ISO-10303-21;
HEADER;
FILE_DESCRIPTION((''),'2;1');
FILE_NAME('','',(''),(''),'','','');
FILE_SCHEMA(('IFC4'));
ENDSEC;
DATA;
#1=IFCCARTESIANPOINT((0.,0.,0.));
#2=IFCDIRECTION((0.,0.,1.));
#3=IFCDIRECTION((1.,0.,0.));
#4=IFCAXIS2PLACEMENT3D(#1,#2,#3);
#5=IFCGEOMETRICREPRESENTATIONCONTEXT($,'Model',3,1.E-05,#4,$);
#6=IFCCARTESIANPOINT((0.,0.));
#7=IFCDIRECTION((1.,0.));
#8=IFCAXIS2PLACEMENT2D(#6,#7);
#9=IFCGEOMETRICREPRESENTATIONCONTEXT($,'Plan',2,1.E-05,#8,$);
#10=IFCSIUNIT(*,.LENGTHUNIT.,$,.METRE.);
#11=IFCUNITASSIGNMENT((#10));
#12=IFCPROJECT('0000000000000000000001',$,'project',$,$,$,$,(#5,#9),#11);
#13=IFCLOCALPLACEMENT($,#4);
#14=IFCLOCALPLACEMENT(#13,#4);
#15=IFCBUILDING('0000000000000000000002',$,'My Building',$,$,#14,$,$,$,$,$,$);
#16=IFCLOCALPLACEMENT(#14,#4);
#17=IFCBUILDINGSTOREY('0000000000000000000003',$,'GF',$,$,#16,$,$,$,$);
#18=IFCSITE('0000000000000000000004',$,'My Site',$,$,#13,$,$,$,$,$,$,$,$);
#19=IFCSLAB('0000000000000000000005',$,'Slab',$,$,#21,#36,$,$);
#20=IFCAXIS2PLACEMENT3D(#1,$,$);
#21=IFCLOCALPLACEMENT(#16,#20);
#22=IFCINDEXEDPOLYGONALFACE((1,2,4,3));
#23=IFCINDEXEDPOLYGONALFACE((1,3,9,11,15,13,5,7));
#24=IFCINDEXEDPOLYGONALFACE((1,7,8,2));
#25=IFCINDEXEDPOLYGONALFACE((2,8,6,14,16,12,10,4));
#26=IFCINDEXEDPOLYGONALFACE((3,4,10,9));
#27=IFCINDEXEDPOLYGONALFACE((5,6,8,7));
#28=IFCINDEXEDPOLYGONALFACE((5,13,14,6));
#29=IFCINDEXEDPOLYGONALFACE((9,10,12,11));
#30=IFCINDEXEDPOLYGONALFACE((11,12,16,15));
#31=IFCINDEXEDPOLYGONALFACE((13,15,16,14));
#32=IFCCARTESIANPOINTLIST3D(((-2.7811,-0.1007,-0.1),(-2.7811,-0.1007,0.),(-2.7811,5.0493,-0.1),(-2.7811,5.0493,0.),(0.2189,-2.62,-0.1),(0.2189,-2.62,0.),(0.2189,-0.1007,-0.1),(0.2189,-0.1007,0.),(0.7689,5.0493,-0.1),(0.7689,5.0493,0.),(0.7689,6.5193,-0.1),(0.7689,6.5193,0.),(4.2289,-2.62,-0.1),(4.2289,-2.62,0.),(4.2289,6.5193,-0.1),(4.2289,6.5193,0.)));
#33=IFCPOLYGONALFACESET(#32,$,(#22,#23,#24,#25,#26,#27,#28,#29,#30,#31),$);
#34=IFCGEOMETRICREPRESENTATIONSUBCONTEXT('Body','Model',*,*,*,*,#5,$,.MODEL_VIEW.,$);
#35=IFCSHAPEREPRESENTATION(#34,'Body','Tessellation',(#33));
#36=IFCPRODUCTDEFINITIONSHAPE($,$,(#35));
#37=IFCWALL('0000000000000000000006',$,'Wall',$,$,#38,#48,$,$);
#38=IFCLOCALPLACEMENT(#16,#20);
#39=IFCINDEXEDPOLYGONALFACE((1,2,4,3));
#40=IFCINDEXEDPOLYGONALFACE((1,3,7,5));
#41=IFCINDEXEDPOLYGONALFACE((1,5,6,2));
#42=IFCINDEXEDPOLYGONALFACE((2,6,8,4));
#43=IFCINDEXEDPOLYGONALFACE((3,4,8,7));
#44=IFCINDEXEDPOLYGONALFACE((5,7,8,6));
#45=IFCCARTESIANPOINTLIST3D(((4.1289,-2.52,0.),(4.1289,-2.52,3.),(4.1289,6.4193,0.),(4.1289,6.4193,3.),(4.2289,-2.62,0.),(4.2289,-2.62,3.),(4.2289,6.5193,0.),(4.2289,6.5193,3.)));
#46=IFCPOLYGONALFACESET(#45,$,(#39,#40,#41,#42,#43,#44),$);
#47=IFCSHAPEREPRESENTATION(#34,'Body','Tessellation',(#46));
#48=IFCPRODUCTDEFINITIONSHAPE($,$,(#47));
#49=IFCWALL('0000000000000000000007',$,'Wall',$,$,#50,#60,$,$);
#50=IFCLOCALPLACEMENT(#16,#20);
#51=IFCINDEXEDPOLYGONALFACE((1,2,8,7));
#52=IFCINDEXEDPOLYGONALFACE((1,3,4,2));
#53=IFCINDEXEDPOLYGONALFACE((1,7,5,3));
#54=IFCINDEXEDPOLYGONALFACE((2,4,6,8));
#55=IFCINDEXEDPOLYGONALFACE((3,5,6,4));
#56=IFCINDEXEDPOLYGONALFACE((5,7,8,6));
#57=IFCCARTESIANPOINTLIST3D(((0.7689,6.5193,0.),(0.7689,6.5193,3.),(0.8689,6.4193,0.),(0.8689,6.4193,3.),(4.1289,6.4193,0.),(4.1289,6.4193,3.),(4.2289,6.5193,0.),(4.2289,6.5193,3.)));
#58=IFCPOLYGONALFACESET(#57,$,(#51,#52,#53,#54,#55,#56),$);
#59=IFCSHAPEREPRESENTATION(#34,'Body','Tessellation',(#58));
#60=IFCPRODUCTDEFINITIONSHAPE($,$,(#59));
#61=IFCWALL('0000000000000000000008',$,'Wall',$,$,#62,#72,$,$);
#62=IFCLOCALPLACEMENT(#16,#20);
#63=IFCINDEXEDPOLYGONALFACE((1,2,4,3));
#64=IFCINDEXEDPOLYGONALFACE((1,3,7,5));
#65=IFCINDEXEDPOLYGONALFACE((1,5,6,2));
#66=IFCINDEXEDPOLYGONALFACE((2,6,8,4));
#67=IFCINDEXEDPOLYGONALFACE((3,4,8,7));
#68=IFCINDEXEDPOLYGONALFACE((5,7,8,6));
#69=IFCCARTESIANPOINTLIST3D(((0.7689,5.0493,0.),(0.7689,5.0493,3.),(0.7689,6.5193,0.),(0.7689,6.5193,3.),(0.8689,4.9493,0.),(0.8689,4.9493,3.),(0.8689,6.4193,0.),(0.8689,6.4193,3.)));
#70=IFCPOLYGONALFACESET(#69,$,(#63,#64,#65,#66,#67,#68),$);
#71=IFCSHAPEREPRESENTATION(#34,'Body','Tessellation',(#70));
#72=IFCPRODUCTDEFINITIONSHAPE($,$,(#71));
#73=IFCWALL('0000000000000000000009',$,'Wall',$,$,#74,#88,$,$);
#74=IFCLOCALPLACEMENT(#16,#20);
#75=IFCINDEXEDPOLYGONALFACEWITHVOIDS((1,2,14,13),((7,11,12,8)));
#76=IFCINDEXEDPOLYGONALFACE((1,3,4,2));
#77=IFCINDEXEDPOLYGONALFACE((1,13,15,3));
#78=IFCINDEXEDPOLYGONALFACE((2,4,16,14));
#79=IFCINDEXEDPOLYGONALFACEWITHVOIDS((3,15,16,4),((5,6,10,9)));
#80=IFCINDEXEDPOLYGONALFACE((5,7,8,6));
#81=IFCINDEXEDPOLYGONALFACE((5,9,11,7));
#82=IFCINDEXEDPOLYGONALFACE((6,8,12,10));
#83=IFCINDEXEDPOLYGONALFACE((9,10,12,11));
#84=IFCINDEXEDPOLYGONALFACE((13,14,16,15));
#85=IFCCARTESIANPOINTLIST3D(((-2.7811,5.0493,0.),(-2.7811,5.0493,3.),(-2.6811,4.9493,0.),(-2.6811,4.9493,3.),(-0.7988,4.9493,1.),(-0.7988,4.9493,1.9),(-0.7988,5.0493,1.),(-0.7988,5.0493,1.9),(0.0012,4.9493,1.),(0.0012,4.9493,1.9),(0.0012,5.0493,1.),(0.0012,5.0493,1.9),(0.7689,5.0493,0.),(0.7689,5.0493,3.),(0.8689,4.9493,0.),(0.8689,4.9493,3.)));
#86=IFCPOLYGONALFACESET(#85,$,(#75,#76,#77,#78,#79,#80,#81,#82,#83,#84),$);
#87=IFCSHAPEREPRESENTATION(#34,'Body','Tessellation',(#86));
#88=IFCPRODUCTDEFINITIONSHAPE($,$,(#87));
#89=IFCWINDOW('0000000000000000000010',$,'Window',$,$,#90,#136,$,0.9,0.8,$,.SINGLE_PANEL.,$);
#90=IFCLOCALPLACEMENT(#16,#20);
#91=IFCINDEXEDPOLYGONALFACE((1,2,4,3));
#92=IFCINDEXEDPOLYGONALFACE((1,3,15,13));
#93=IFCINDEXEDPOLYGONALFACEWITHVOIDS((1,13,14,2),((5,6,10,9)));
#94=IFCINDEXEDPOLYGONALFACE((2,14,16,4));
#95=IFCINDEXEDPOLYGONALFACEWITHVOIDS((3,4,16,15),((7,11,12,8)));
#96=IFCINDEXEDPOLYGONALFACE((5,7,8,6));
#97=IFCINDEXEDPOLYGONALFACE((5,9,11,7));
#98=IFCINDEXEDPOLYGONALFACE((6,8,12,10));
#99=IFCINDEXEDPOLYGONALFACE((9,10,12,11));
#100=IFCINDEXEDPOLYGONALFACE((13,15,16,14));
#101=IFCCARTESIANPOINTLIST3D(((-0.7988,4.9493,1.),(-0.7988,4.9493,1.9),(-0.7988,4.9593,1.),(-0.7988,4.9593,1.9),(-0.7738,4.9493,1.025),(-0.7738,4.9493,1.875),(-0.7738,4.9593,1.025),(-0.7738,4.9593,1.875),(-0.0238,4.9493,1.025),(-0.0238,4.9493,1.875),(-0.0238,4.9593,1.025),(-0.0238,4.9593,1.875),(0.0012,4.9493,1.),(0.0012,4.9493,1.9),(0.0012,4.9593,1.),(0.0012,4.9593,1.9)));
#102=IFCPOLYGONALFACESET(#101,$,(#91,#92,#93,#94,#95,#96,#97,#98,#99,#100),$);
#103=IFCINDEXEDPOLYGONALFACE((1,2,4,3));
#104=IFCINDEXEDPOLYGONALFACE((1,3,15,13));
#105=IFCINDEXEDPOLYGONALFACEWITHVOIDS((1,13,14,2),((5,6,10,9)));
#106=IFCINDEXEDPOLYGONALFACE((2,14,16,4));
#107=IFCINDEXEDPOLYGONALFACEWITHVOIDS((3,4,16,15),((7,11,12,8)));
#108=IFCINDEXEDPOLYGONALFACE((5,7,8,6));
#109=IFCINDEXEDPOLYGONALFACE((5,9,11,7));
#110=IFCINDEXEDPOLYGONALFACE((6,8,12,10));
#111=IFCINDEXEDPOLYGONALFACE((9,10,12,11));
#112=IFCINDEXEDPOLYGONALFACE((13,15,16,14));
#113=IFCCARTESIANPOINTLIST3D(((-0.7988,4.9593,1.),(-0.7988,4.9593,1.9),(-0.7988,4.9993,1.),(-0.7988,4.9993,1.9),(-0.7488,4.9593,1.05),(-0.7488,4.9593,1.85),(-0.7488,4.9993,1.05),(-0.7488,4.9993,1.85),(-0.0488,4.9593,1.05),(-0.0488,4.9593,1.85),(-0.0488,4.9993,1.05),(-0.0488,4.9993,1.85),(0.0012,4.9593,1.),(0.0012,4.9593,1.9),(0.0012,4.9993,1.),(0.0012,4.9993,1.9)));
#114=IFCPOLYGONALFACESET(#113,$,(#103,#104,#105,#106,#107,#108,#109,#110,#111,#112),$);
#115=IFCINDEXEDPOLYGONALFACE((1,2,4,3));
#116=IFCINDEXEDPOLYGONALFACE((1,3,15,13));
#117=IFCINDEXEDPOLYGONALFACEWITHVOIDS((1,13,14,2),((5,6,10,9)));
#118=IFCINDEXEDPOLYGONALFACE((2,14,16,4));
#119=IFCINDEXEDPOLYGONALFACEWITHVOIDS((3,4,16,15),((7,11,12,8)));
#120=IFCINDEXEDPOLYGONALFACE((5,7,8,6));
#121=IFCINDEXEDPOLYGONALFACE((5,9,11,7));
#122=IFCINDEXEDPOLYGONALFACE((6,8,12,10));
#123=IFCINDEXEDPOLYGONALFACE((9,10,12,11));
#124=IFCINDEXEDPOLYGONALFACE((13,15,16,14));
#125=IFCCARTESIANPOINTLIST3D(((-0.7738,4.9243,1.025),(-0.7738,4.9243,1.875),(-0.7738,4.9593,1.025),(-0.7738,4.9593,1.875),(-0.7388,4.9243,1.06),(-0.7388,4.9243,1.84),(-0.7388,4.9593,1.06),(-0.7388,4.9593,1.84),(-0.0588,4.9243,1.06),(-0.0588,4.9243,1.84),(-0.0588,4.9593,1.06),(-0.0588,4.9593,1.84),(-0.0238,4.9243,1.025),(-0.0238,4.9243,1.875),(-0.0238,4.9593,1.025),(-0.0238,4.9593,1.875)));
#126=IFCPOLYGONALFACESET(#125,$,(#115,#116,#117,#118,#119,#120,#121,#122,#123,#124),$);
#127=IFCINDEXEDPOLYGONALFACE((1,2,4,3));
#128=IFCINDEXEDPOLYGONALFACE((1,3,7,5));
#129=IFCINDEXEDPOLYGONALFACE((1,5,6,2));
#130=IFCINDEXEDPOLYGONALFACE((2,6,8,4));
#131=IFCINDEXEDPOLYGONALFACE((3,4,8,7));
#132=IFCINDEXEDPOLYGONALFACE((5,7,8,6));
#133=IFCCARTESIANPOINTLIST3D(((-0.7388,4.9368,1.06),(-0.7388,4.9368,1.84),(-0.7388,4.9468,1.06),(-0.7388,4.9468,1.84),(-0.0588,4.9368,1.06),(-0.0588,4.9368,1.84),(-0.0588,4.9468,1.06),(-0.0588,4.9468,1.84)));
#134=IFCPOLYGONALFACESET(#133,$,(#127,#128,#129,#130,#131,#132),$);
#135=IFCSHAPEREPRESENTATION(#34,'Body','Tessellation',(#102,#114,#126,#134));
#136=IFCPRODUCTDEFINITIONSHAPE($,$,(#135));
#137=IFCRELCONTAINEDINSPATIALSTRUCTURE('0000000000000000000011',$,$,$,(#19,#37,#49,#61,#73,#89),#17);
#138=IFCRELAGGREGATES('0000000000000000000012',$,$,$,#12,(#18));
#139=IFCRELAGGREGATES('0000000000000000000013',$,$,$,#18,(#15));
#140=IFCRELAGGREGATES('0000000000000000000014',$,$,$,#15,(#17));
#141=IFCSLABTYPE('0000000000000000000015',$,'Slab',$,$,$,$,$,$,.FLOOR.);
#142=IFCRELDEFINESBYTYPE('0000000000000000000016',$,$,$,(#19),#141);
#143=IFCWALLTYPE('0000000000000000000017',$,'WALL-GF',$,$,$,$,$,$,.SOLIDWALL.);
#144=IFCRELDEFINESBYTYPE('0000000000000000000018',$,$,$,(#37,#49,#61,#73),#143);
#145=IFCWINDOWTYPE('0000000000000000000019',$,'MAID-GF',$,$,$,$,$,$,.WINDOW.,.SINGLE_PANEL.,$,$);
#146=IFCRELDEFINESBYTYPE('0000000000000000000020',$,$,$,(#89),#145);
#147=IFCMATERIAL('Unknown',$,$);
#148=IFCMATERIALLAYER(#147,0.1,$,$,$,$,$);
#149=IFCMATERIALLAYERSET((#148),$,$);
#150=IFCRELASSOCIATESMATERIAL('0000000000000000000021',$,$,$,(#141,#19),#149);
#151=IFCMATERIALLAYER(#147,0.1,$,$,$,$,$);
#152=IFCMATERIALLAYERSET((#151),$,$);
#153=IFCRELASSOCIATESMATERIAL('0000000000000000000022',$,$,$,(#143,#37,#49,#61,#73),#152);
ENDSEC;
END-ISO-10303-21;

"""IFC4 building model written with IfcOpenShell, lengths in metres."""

from ifc_helpers import new_model, entity, si_unit, frame, origin_with_axes, origin_2d_with_axis, place, context, subcontext, project, spatial, line, indexed_curve, outline, extrude, shape, source, transform, mapped, material, layer, layer_set, layer_usage, type_object, type_shapes, element, fill, save


model = new_model("IFC4")

# Units and contexts
model_context = context("Model", 3, precision=1e-05, world=origin_with_axes())
plan_context = context("Plan", 2, precision=1e-05, world=origin_2d_with_axis())
body_context_1 = subcontext(model_context, "Body", "Model", "MODEL_VIEW")
body_context_2 = subcontext(plan_context, "Body", "Plan", "PLAN_VIEW")
ifc_project = project(units=[si_unit("LENGTHUNIT", "METRE")], contexts=[model_context, plan_context])

# Site, building, storey
site_placement = place(None, origin_with_axes())
site = spatial("IfcSite", under=ifc_project, at=site_placement, Name="My Site")
building_placement = place(site_placement, origin_with_axes())
building = spatial("IfcBuilding", under=site, at=building_placement, Name="My Building")
storey_placement = place(building_placement, origin_with_axes())
storey = spatial("IfcBuildingStorey", under=building, at=storey_placement, Name="GF")

# Slab
ifc_material_1 = material(Name="Unknown")
ifc_layer_1 = layer(ifc_material_1, 0.1)
ifc_layer_set_1 = layer_set([ifc_layer_1])
ifc_layer_usage_1 = layer_usage(ifc_layer_set_1, "AXIS3", "POSITIVE", -0.1)
slab_type_1 = type_object("IfcSlabType", Name="Slab", PredefinedType="FLOOR", material=ifc_layer_set_1)
slab_1_placement = place(storey_placement, frame((4.2289, 6.5193, 0.0), z_axis=(0.0, 0.0, 1.0), x_axis=(1.0, 0.0, 0.0)))
element("IfcSlab", 1, at=slab_1_placement, inside=storey, type_object=slab_type_1, material=ifc_layer_usage_1, Name="Slab", context=body_context_1, shape_type="SweptSolid", body=[
    extrude(outline(indexed_curve([(0.0, 0.0), (-3.46, 0.0), (-3.46, -1.47), (-7.01, -1.47), (-7.01, -6.62), (-4.01, -6.62), (-4.01, -9.1393), (0.0, -9.1393), (0.0, 0.0)])), frame((0.0, 0.0, -0.1), z_axis=(0.0, 0.0, 1.0), x_axis=(1.0, 0.0, 0.0)), (0.0, 0.0, 1.0), 0.1),
])

# Shared definitions
ifc_layer_2 = layer(ifc_material_1, 0.1)
ifc_layer_set_2 = layer_set([ifc_layer_2])
wall_type = type_object("IfcWallType", Name="WALL-GF", PredefinedType="SOLIDWALL", material=ifc_layer_set_2)

# Walls
ifc_layer_usage_2 = layer_usage(ifc_layer_set_2, "AXIS2", "POSITIVE", 0.0)
wall_1_placement = place(storey_placement, frame((4.2289, -2.62, 0.0), z_axis=(0.0, 0.0, 1.0), x_axis=(0.0, 1.0, 0.0)))
element("IfcWall", 2, at=wall_1_placement, inside=storey, type_object=wall_type, material=ifc_layer_usage_2, Name="Wall", context=body_context_1, shape_type="SweptSolid", body=[
    extrude(outline(indexed_curve([(0.0, 0.0), (0.1, 0.1), (9.0393, 0.1), (9.1393, 0.0)], segments=[line(1, 2, 3, 4, 1)])), origin_with_axes(), (0.0, 0.0, 1.0), 3.0),
])
ifc_layer_usage_3 = layer_usage(ifc_layer_set_2, "AXIS2", "POSITIVE", 0.0)
wall_2_placement = place(storey_placement, frame((4.2289, 6.5193, 0.0), z_axis=(0.0, 0.0, 1.0), x_axis=(-1.0, 0.0, 0.0)))
element("IfcWall", 3, at=wall_2_placement, inside=storey, type_object=wall_type, material=ifc_layer_usage_3, Name="Wall", context=body_context_1, shape_type="SweptSolid", body=[
    extrude(outline(indexed_curve([(0.0, 0.0), (0.1, 0.1), (3.36, 0.1), (3.46, 0.0)], segments=[line(1, 2, 3, 4, 1)])), origin_with_axes(), (0.0, 0.0, 1.0), 3.0),
])
ifc_layer_usage_4 = layer_usage(ifc_layer_set_2, "AXIS2", "POSITIVE", 0.0)
wall_3_placement = place(storey_placement, frame((0.7689, 6.5193, 0.0), z_axis=(0.0, 0.0, 1.0), x_axis=(0.0, -1.0, 0.0)))
element("IfcWall", 4, at=wall_3_placement, inside=storey, type_object=wall_type, material=ifc_layer_usage_4, Name="Wall", context=body_context_1, shape_type="SweptSolid", body=[
    extrude(outline(indexed_curve([(0.0, 0.0), (0.1, 0.1), (1.57, 0.1), (1.47, 0.0)], segments=[line(1, 2, 3, 4, 1)])), origin_with_axes(), (0.0, 0.0, 1.0), 3.0),
])

# Wall, opening, window
ifc_layer_usage_5 = layer_usage(ifc_layer_set_2, "AXIS2", "POSITIVE", 0.0)
wall_4_placement = place(storey_placement, frame((0.7689, 5.0493, 0.0), z_axis=(0.0, 0.0, 1.0), x_axis=(-1.0, 0.0, 0.0)))
wall_4 = element("IfcWall", 5, at=wall_4_placement, inside=storey, type_object=wall_type, material=ifc_layer_usage_5, Name="Wall", context=body_context_1, shape_type="SweptSolid", body=[
    extrude(outline(indexed_curve([(0.0, 0.0), (-0.1, 0.1), (3.45, 0.1), (3.55, 0.0)], segments=[line(1, 2, 3, 4, 1)])), origin_with_axes(), (0.0, 0.0, 1.0), 3.0),
])
shared_shape_1 = source(origin_with_axes(), body_context_1, "Body", "SweptSolid", [
    extrude(outline(indexed_curve([(0.0, 0.0), (0.8, 0.0), (0.8, 0.9), (0.0, 0.9)], segments=[line(1, 2, 3, 4, 1)])), frame((0.0, -0.6, 0.0), z_axis=(0.0, -1.0, 0.0), x_axis=(1.0, 0.0, 0.0)), (0.0, 0.0, -1.0), 1.2),
])
opening_1_placement = place(wall_4_placement, frame((0.7678, 0.0, 1.0), z_axis=(0.0, 0.0, 1.0), x_axis=(1.0, 0.0, 0.0)))
opening_1 = element("IfcOpeningElement", 6, at=opening_1_placement, cuts=wall_4, PredefinedType="OPENING", context=body_context_1, shape_type="MappedRepresentation", body=[
    mapped(shared_shape_1, transform((0.0, 0.0, 0.0), x_axis=(1.0, 0.0, 0.0), y_axis=(0.0, 1.0, 0.0), z_axis=(0.0, 0.0, 1.0), scale=1.0)),
])
window_type_1 = type_object("IfcWindowType", Name="MAID-GF", PartitioningType="SINGLE_PANEL", PredefinedType="WINDOW")
shared_shape_2 = source(origin_with_axes(), body_context_1, "Body", "SweptSolid", [
    extrude(outline(indexed_curve([(0.0, 0.0), (0.8, 0.0), (0.8, 0.9), (0.0, 0.9)], segments=[line(1, 2, 3, 4, 1)]), holes=[indexed_curve([(0.025, 0.025), (0.775, 0.025), (0.775, 0.875), (0.025, 0.875)], segments=[line(1, 2, 3, 4, 1)])]), frame((0.0, 0.09, 0.0), z_axis=(0.0, -1.0, 0.0), x_axis=(1.0, 0.0, 0.0)), (0.0, 0.0, -1.0), 0.01),
    extrude(outline(indexed_curve([(0.0, 0.0), (0.8, 0.0), (0.8, 0.9), (0.0, 0.9)], segments=[line(1, 2, 3, 4, 1)]), holes=[indexed_curve([(0.05, 0.05), (0.75, 0.05), (0.75, 0.85), (0.05, 0.85)], segments=[line(1, 2, 3, 4, 1)])]), frame((0.0, 0.05, 0.0), z_axis=(0.0, -1.0, 0.0), x_axis=(1.0, 0.0, 0.0)), (0.0, 0.0, -1.0), 0.04),
    extrude(outline(indexed_curve([(0.0, 0.0), (0.75, 0.0), (0.75, 0.85), (0.0, 0.85)], segments=[line(1, 2, 3, 4, 1)]), holes=[indexed_curve([(0.035, 0.035), (0.715, 0.035), (0.715, 0.815), (0.035, 0.815)], segments=[line(1, 2, 3, 4, 1)])]), frame((0.025, 0.09, 0.025), z_axis=(0.0, -1.0, 0.0), x_axis=(1.0, 0.0, 0.0)), (0.0, 0.0, -1.0), 0.035),
    extrude(outline(indexed_curve([(0.035, 0.035), (0.715, 0.035), (0.715, 0.815), (0.035, 0.815)], segments=[line(1, 2, 3, 4, 1)])), frame((0.025, 0.1025, 0.025), z_axis=(0.0, -1.0, 0.0), x_axis=(1.0, 0.0, 0.0)), (0.0, 0.0, -1.0), 0.01),
])
shared_shape_3 = source(origin_with_axes(), body_context_2, "Body", "Curve2D", [
    entity("IfcIndexedPolyCurve", entity("IfcCartesianPointList2D", [[0.05, 0.05], [0.75, 0.05]])),
    entity("IfcIndexedPolyCurve", entity("IfcCartesianPointList2D", [[0.0, 0.1], [0.025, 0.1], [0.025, 0.09], [0.05, 0.09], [0.05, 0.05], [0.0, 0.05]]), [entity("IfcLineIndex", [1, 2, 3, 4, 5, 6, 1])]),
    entity("IfcIndexedPolyCurve", entity("IfcCartesianPointList2D", [[0.8, 0.1], [0.775, 0.1], [0.775, 0.09], [0.75, 0.09], [0.75, 0.05], [0.8, 0.05]]), [entity("IfcLineIndex", [1, 2, 3, 4, 5, 6, 1])]),
    entity("IfcIndexedPolyCurve", entity("IfcCartesianPointList2D", [[0.025, 0.09], [0.06, 0.09], [0.06, 0.125], [0.025, 0.125]]), [entity("IfcLineIndex", [1, 2, 3, 4, 1])]),
    entity("IfcIndexedPolyCurve", entity("IfcCartesianPointList2D", [[0.775, 0.09], [0.74, 0.09], [0.74, 0.125], [0.775, 0.125]]), [entity("IfcLineIndex", [1, 2, 3, 4, 1])]),
    entity("IfcIndexedPolyCurve", entity("IfcCartesianPointList2D", [[0.06, 0.09], [0.74, 0.09]])),
    entity("IfcIndexedPolyCurve", entity("IfcCartesianPointList2D", [[0.06, 0.125], [0.74, 0.125]])),
    entity("IfcIndexedPolyCurve", entity("IfcCartesianPointList2D", [[0.06, 0.1075], [0.74, 0.1075]])),
])
type_shapes(window_type_1, [shared_shape_2, shared_shape_3])
window_1_placement = place(opening_1_placement, frame((0.0, 0.0, 0.0), z_axis=(0.0, 0.0, 1.0), x_axis=(1.0, 0.0, 0.0)))
window_1 = element("IfcWindow", 7, at=window_1_placement, inside=storey, type_object=window_type_1, Name="Window", OverallHeight=0.9, OverallWidth=0.8, PartitioningType="SINGLE_PANEL", shapes=[
    shape(body_context_1, "Body", "MappedRepresentation", [mapped(shared_shape_2, transform((0.0, 0.0, 0.0), x_axis=(1.0, 0.0, 0.0), y_axis=(0.0, 1.0, 0.0), z_axis=(0.0, 0.0, 1.0), scale=1.0))]),
    shape(body_context_2, "Body", "MappedRepresentation", [mapped(shared_shape_3, transform((0.0, 0.0, 0.0), x_axis=(1.0, 0.0, 0.0), y_axis=(0.0, 1.0, 0.0), z_axis=(0.0, 0.0, 1.0), scale=1.0))]),
])
fill(opening_1, window_1)

save(model, "model.ifc")
